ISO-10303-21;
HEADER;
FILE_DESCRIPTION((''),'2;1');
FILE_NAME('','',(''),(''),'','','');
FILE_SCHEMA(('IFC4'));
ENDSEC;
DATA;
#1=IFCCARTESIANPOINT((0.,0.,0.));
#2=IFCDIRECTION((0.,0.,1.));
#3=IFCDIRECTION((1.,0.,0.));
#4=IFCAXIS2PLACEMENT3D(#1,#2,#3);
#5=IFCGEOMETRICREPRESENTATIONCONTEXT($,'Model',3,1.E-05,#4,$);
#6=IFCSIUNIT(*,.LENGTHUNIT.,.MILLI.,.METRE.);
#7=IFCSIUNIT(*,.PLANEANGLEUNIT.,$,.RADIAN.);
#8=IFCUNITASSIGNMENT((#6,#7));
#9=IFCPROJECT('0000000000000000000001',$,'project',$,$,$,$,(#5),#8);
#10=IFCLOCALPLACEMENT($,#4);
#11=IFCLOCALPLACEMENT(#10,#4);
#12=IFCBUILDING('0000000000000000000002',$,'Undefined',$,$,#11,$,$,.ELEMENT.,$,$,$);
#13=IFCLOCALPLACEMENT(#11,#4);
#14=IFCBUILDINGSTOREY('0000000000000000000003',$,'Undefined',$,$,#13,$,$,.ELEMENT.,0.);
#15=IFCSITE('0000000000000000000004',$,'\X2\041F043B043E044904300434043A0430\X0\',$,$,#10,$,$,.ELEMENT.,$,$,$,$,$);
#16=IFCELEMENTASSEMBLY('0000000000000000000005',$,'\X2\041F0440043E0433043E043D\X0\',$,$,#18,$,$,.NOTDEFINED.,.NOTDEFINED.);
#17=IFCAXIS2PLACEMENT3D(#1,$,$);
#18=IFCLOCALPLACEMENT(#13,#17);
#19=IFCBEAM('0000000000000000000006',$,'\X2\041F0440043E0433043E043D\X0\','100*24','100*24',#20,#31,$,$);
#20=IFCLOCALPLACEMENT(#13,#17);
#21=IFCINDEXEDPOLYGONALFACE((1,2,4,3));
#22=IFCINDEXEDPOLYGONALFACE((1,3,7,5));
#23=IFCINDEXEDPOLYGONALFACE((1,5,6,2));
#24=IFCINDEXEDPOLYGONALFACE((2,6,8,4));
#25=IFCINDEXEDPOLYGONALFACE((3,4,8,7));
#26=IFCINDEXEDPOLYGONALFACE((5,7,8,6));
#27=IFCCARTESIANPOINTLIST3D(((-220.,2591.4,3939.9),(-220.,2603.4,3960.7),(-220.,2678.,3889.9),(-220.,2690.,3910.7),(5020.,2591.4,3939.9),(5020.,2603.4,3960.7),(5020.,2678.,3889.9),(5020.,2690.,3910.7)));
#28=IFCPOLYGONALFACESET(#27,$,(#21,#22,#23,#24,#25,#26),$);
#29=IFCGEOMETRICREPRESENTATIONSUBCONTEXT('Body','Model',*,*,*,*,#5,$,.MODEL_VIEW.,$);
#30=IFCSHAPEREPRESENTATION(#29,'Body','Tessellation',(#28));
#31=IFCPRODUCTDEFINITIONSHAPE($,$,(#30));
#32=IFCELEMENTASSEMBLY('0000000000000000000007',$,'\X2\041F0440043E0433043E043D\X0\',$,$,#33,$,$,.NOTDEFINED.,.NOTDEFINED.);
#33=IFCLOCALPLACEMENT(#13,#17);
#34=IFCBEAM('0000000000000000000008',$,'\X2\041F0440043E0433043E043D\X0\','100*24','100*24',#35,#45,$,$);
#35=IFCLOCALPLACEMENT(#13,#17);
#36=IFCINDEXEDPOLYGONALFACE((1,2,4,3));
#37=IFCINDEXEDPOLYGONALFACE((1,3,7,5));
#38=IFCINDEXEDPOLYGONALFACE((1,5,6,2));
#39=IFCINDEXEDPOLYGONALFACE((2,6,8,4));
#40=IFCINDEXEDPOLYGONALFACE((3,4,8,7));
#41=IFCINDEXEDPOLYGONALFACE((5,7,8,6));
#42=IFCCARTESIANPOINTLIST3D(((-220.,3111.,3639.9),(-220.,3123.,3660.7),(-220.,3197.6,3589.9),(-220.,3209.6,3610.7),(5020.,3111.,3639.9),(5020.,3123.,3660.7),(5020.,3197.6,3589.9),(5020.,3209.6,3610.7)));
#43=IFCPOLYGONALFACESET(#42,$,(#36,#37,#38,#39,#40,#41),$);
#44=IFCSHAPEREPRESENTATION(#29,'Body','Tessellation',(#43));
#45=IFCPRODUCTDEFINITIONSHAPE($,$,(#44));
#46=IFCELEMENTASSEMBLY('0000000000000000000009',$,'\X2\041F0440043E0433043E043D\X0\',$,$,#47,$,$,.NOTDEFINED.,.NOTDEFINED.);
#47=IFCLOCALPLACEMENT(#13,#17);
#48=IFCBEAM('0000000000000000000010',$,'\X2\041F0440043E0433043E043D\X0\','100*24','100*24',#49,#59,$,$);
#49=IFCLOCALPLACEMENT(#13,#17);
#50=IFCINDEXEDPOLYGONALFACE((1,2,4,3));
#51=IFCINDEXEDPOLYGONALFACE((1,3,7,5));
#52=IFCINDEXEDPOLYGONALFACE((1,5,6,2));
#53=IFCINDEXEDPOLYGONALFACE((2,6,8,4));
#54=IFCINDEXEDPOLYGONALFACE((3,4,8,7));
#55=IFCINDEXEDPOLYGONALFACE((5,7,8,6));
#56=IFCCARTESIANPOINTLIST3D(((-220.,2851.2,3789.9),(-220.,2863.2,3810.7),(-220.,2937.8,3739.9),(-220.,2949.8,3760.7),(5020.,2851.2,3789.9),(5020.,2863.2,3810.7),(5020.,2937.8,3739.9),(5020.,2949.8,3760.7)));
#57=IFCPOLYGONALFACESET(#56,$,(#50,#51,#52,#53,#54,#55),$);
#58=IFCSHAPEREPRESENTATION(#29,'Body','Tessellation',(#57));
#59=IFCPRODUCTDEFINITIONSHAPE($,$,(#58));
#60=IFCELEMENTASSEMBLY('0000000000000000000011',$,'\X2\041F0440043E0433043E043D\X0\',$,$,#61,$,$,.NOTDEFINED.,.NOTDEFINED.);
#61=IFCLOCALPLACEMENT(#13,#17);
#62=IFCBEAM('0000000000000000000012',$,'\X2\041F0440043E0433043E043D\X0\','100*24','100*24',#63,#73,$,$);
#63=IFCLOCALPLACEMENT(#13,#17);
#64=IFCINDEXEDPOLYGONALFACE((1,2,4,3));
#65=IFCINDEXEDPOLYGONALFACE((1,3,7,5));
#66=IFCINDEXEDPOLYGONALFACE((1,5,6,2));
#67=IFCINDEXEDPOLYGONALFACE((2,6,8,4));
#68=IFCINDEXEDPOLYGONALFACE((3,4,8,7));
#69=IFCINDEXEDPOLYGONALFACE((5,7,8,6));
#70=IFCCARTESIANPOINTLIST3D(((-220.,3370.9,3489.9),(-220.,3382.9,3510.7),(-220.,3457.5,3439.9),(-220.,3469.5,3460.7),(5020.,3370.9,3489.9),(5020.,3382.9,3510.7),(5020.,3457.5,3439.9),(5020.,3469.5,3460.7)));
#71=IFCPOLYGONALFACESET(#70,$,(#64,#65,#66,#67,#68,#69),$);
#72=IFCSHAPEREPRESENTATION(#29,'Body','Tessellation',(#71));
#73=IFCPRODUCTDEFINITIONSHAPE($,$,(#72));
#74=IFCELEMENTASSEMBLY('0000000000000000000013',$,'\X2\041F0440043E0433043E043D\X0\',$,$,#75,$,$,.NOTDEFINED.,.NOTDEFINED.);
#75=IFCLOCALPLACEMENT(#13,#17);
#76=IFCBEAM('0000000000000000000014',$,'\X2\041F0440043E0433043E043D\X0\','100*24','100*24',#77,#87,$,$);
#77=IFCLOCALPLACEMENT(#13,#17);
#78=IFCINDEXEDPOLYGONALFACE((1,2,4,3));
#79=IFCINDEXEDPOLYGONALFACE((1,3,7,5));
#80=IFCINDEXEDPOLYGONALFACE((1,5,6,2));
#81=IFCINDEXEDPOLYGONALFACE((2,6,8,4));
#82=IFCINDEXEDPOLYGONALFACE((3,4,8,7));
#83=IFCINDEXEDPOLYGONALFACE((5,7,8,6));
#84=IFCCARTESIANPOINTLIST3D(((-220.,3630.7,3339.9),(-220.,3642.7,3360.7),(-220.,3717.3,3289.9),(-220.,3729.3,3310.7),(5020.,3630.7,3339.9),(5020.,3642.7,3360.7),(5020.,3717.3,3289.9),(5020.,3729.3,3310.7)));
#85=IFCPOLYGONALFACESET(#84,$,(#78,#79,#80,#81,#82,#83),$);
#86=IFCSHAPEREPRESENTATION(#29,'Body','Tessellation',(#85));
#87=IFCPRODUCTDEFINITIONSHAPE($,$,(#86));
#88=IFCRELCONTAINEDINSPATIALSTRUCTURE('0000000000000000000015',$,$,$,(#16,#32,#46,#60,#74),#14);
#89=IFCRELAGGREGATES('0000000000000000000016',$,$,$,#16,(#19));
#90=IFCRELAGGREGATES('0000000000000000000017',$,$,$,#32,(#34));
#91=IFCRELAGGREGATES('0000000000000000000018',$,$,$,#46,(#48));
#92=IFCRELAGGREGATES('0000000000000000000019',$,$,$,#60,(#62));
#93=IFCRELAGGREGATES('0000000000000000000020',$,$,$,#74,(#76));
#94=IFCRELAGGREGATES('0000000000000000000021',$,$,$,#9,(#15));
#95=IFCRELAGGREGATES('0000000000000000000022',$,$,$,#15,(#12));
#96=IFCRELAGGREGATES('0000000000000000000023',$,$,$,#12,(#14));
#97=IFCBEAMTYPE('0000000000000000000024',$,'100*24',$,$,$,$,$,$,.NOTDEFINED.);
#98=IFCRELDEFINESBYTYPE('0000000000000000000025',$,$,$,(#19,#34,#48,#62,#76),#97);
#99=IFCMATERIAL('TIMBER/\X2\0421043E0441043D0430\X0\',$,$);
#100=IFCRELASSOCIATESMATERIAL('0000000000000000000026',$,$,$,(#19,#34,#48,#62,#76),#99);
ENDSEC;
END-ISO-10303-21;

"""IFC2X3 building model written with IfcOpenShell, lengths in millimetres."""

from ifc_helpers import new_model, si_unit, frame, origin_with_axes, origin_2d_with_axis, place, context, subcontext, project, spatial, rectangle, extrude, material, type_object, element, aggregate, save


model = new_model("IFC2X3")

# Units and contexts
model_context = context("Model", 3, precision=1e-05, world=origin_with_axes())
body_context = subcontext(model_context, "Body", "Model", "MODEL_VIEW")
ifc_project = project(units=[si_unit("LENGTHUNIT", "METRE", prefix="MILLI"), si_unit("PLANEANGLEUNIT", "RADIAN")], contexts=[model_context])

# Site, building, storey
site_placement = place(None, origin_with_axes())
site = spatial("IfcSite", under=ifc_project, at=site_placement, Name="Площадка", CompositionType="ELEMENT")
building_placement = place(site_placement, origin_with_axes())
building = spatial("IfcBuilding", under=site, at=building_placement, Name="Undefined", CompositionType="ELEMENT")
storey_placement = place(building_placement, origin_with_axes())
storey = spatial("IfcBuildingStorey", under=building, at=storey_placement, Name="Undefined", CompositionType="ELEMENT", Elevation=0.0)

# Shared definitions
ifc_material = material(Name="TIMBER/Сосна")

# Element assemblies, beams
assembly_1_placement = place(storey_placement, origin_with_axes())
assembly_1 = element("IfcElementAssembly", 1, at=assembly_1_placement, inside=storey, Name="Прогон", AssemblyPlace="NOTDEFINED", PredefinedType="NOTDEFINED")
beam_type_1 = type_object("IfcBeamType", Name="100*24", PredefinedType="NOTDEFINED")
beam_1_placement = place(assembly_1_placement, frame((-220.0, 2640.7, 3925.3), z_axis=(0.0, -0.866025, 0.5), x_axis=(1.0, 0.0, 0.0)))
beam_1 = element("IfcBeam", 2, at=beam_1_placement, type_object=beam_type_1, material=ifc_material, Name="Прогон", Description="100*24", ObjectType="100*24", context=body_context, shape_type="SweptSolid", body=[
    extrude(rectangle(XDim=24.0, YDim=100.0, at=origin_2d_with_axis()), frame((5240.0, 0.0, 0.0), z_axis=(-1.0, 0.0, 0.0), x_axis=(0.0, -1.0, 0.0)), (0.0, 0.0, 1.0), 5240.0),
])
aggregate(assembly_1, [beam_1])
assembly_2_placement = place(storey_placement, origin_with_axes())
assembly_2 = element("IfcElementAssembly", 3, at=assembly_2_placement, inside=storey, Name="Прогон", AssemblyPlace="NOTDEFINED", PredefinedType="NOTDEFINED")
beam_2_placement = place(assembly_2_placement, frame((-220.0, 3160.3, 3625.3), z_axis=(0.0, -0.866025, 0.5), x_axis=(1.0, 0.0, 0.0)))
beam_2 = element("IfcBeam", 4, at=beam_2_placement, type_object=beam_type_1, material=ifc_material, Name="Прогон", Description="100*24", ObjectType="100*24", context=body_context, shape_type="SweptSolid", body=[
    extrude(rectangle(XDim=24.0, YDim=100.0, at=origin_2d_with_axis()), frame((5240.0, 0.0, 0.0), z_axis=(-1.0, 0.0, 0.0), x_axis=(0.0, -1.0, 0.0)), (0.0, 0.0, 1.0), 5240.0),
])
aggregate(assembly_2, [beam_2])
assembly_3_placement = place(storey_placement, origin_with_axes())
assembly_3 = element("IfcElementAssembly", 5, at=assembly_3_placement, inside=storey, Name="Прогон", AssemblyPlace="NOTDEFINED", PredefinedType="NOTDEFINED")
beam_3_placement = place(assembly_3_placement, frame((-220.0, 2900.5, 3775.3), z_axis=(0.0, -0.866025, 0.5), x_axis=(1.0, 0.0, 0.0)))
beam_3 = element("IfcBeam", 6, at=beam_3_placement, type_object=beam_type_1, material=ifc_material, Name="Прогон", Description="100*24", ObjectType="100*24", context=body_context, shape_type="SweptSolid", body=[
    extrude(rectangle(XDim=24.0, YDim=100.0, at=origin_2d_with_axis()), frame((5240.0, 0.0, 0.0), z_axis=(-1.0, 0.0, 0.0), x_axis=(0.0, -1.0, 0.0)), (0.0, 0.0, 1.0), 5240.0),
])
aggregate(assembly_3, [beam_3])
assembly_4_placement = place(storey_placement, origin_with_axes())
assembly_4 = element("IfcElementAssembly", 7, at=assembly_4_placement, inside=storey, Name="Прогон", AssemblyPlace="NOTDEFINED", PredefinedType="NOTDEFINED")
beam_4_placement = place(assembly_4_placement, frame((-220.0, 3420.2, 3475.3), z_axis=(0.0, -0.866025, 0.5), x_axis=(1.0, 0.0, 0.0)))
beam_4 = element("IfcBeam", 8, at=beam_4_placement, type_object=beam_type_1, material=ifc_material, Name="Прогон", Description="100*24", ObjectType="100*24", context=body_context, shape_type="SweptSolid", body=[
    extrude(rectangle(XDim=24.0, YDim=100.0, at=origin_2d_with_axis()), frame((5240.0, 0.0, 0.0), z_axis=(-1.0, 0.0, 0.0), x_axis=(0.0, -1.0, 0.0)), (0.0, 0.0, 1.0), 5240.0),
])
aggregate(assembly_4, [beam_4])
assembly_5_placement = place(storey_placement, origin_with_axes())
assembly_5 = element("IfcElementAssembly", 9, at=assembly_5_placement, inside=storey, Name="Прогон", AssemblyPlace="NOTDEFINED", PredefinedType="NOTDEFINED")
beam_5_placement = place(assembly_5_placement, frame((-220.0, 3680.0, 3325.3), z_axis=(0.0, -0.866025, 0.5), x_axis=(1.0, 0.0, 0.0)))
beam_5 = element("IfcBeam", 10, at=beam_5_placement, type_object=beam_type_1, material=ifc_material, Name="Прогон", Description="100*24", ObjectType="100*24", context=body_context, shape_type="SweptSolid", body=[
    extrude(rectangle(XDim=24.0, YDim=100.0, at=origin_2d_with_axis()), frame((5240.0, 0.0, 0.0), z_axis=(-1.0, 0.0, 0.0), x_axis=(0.0, -1.0, 0.0)), (0.0, 0.0, 1.0), 5240.0),
])
aggregate(assembly_5, [beam_5])

save(model, "model.ifc")
